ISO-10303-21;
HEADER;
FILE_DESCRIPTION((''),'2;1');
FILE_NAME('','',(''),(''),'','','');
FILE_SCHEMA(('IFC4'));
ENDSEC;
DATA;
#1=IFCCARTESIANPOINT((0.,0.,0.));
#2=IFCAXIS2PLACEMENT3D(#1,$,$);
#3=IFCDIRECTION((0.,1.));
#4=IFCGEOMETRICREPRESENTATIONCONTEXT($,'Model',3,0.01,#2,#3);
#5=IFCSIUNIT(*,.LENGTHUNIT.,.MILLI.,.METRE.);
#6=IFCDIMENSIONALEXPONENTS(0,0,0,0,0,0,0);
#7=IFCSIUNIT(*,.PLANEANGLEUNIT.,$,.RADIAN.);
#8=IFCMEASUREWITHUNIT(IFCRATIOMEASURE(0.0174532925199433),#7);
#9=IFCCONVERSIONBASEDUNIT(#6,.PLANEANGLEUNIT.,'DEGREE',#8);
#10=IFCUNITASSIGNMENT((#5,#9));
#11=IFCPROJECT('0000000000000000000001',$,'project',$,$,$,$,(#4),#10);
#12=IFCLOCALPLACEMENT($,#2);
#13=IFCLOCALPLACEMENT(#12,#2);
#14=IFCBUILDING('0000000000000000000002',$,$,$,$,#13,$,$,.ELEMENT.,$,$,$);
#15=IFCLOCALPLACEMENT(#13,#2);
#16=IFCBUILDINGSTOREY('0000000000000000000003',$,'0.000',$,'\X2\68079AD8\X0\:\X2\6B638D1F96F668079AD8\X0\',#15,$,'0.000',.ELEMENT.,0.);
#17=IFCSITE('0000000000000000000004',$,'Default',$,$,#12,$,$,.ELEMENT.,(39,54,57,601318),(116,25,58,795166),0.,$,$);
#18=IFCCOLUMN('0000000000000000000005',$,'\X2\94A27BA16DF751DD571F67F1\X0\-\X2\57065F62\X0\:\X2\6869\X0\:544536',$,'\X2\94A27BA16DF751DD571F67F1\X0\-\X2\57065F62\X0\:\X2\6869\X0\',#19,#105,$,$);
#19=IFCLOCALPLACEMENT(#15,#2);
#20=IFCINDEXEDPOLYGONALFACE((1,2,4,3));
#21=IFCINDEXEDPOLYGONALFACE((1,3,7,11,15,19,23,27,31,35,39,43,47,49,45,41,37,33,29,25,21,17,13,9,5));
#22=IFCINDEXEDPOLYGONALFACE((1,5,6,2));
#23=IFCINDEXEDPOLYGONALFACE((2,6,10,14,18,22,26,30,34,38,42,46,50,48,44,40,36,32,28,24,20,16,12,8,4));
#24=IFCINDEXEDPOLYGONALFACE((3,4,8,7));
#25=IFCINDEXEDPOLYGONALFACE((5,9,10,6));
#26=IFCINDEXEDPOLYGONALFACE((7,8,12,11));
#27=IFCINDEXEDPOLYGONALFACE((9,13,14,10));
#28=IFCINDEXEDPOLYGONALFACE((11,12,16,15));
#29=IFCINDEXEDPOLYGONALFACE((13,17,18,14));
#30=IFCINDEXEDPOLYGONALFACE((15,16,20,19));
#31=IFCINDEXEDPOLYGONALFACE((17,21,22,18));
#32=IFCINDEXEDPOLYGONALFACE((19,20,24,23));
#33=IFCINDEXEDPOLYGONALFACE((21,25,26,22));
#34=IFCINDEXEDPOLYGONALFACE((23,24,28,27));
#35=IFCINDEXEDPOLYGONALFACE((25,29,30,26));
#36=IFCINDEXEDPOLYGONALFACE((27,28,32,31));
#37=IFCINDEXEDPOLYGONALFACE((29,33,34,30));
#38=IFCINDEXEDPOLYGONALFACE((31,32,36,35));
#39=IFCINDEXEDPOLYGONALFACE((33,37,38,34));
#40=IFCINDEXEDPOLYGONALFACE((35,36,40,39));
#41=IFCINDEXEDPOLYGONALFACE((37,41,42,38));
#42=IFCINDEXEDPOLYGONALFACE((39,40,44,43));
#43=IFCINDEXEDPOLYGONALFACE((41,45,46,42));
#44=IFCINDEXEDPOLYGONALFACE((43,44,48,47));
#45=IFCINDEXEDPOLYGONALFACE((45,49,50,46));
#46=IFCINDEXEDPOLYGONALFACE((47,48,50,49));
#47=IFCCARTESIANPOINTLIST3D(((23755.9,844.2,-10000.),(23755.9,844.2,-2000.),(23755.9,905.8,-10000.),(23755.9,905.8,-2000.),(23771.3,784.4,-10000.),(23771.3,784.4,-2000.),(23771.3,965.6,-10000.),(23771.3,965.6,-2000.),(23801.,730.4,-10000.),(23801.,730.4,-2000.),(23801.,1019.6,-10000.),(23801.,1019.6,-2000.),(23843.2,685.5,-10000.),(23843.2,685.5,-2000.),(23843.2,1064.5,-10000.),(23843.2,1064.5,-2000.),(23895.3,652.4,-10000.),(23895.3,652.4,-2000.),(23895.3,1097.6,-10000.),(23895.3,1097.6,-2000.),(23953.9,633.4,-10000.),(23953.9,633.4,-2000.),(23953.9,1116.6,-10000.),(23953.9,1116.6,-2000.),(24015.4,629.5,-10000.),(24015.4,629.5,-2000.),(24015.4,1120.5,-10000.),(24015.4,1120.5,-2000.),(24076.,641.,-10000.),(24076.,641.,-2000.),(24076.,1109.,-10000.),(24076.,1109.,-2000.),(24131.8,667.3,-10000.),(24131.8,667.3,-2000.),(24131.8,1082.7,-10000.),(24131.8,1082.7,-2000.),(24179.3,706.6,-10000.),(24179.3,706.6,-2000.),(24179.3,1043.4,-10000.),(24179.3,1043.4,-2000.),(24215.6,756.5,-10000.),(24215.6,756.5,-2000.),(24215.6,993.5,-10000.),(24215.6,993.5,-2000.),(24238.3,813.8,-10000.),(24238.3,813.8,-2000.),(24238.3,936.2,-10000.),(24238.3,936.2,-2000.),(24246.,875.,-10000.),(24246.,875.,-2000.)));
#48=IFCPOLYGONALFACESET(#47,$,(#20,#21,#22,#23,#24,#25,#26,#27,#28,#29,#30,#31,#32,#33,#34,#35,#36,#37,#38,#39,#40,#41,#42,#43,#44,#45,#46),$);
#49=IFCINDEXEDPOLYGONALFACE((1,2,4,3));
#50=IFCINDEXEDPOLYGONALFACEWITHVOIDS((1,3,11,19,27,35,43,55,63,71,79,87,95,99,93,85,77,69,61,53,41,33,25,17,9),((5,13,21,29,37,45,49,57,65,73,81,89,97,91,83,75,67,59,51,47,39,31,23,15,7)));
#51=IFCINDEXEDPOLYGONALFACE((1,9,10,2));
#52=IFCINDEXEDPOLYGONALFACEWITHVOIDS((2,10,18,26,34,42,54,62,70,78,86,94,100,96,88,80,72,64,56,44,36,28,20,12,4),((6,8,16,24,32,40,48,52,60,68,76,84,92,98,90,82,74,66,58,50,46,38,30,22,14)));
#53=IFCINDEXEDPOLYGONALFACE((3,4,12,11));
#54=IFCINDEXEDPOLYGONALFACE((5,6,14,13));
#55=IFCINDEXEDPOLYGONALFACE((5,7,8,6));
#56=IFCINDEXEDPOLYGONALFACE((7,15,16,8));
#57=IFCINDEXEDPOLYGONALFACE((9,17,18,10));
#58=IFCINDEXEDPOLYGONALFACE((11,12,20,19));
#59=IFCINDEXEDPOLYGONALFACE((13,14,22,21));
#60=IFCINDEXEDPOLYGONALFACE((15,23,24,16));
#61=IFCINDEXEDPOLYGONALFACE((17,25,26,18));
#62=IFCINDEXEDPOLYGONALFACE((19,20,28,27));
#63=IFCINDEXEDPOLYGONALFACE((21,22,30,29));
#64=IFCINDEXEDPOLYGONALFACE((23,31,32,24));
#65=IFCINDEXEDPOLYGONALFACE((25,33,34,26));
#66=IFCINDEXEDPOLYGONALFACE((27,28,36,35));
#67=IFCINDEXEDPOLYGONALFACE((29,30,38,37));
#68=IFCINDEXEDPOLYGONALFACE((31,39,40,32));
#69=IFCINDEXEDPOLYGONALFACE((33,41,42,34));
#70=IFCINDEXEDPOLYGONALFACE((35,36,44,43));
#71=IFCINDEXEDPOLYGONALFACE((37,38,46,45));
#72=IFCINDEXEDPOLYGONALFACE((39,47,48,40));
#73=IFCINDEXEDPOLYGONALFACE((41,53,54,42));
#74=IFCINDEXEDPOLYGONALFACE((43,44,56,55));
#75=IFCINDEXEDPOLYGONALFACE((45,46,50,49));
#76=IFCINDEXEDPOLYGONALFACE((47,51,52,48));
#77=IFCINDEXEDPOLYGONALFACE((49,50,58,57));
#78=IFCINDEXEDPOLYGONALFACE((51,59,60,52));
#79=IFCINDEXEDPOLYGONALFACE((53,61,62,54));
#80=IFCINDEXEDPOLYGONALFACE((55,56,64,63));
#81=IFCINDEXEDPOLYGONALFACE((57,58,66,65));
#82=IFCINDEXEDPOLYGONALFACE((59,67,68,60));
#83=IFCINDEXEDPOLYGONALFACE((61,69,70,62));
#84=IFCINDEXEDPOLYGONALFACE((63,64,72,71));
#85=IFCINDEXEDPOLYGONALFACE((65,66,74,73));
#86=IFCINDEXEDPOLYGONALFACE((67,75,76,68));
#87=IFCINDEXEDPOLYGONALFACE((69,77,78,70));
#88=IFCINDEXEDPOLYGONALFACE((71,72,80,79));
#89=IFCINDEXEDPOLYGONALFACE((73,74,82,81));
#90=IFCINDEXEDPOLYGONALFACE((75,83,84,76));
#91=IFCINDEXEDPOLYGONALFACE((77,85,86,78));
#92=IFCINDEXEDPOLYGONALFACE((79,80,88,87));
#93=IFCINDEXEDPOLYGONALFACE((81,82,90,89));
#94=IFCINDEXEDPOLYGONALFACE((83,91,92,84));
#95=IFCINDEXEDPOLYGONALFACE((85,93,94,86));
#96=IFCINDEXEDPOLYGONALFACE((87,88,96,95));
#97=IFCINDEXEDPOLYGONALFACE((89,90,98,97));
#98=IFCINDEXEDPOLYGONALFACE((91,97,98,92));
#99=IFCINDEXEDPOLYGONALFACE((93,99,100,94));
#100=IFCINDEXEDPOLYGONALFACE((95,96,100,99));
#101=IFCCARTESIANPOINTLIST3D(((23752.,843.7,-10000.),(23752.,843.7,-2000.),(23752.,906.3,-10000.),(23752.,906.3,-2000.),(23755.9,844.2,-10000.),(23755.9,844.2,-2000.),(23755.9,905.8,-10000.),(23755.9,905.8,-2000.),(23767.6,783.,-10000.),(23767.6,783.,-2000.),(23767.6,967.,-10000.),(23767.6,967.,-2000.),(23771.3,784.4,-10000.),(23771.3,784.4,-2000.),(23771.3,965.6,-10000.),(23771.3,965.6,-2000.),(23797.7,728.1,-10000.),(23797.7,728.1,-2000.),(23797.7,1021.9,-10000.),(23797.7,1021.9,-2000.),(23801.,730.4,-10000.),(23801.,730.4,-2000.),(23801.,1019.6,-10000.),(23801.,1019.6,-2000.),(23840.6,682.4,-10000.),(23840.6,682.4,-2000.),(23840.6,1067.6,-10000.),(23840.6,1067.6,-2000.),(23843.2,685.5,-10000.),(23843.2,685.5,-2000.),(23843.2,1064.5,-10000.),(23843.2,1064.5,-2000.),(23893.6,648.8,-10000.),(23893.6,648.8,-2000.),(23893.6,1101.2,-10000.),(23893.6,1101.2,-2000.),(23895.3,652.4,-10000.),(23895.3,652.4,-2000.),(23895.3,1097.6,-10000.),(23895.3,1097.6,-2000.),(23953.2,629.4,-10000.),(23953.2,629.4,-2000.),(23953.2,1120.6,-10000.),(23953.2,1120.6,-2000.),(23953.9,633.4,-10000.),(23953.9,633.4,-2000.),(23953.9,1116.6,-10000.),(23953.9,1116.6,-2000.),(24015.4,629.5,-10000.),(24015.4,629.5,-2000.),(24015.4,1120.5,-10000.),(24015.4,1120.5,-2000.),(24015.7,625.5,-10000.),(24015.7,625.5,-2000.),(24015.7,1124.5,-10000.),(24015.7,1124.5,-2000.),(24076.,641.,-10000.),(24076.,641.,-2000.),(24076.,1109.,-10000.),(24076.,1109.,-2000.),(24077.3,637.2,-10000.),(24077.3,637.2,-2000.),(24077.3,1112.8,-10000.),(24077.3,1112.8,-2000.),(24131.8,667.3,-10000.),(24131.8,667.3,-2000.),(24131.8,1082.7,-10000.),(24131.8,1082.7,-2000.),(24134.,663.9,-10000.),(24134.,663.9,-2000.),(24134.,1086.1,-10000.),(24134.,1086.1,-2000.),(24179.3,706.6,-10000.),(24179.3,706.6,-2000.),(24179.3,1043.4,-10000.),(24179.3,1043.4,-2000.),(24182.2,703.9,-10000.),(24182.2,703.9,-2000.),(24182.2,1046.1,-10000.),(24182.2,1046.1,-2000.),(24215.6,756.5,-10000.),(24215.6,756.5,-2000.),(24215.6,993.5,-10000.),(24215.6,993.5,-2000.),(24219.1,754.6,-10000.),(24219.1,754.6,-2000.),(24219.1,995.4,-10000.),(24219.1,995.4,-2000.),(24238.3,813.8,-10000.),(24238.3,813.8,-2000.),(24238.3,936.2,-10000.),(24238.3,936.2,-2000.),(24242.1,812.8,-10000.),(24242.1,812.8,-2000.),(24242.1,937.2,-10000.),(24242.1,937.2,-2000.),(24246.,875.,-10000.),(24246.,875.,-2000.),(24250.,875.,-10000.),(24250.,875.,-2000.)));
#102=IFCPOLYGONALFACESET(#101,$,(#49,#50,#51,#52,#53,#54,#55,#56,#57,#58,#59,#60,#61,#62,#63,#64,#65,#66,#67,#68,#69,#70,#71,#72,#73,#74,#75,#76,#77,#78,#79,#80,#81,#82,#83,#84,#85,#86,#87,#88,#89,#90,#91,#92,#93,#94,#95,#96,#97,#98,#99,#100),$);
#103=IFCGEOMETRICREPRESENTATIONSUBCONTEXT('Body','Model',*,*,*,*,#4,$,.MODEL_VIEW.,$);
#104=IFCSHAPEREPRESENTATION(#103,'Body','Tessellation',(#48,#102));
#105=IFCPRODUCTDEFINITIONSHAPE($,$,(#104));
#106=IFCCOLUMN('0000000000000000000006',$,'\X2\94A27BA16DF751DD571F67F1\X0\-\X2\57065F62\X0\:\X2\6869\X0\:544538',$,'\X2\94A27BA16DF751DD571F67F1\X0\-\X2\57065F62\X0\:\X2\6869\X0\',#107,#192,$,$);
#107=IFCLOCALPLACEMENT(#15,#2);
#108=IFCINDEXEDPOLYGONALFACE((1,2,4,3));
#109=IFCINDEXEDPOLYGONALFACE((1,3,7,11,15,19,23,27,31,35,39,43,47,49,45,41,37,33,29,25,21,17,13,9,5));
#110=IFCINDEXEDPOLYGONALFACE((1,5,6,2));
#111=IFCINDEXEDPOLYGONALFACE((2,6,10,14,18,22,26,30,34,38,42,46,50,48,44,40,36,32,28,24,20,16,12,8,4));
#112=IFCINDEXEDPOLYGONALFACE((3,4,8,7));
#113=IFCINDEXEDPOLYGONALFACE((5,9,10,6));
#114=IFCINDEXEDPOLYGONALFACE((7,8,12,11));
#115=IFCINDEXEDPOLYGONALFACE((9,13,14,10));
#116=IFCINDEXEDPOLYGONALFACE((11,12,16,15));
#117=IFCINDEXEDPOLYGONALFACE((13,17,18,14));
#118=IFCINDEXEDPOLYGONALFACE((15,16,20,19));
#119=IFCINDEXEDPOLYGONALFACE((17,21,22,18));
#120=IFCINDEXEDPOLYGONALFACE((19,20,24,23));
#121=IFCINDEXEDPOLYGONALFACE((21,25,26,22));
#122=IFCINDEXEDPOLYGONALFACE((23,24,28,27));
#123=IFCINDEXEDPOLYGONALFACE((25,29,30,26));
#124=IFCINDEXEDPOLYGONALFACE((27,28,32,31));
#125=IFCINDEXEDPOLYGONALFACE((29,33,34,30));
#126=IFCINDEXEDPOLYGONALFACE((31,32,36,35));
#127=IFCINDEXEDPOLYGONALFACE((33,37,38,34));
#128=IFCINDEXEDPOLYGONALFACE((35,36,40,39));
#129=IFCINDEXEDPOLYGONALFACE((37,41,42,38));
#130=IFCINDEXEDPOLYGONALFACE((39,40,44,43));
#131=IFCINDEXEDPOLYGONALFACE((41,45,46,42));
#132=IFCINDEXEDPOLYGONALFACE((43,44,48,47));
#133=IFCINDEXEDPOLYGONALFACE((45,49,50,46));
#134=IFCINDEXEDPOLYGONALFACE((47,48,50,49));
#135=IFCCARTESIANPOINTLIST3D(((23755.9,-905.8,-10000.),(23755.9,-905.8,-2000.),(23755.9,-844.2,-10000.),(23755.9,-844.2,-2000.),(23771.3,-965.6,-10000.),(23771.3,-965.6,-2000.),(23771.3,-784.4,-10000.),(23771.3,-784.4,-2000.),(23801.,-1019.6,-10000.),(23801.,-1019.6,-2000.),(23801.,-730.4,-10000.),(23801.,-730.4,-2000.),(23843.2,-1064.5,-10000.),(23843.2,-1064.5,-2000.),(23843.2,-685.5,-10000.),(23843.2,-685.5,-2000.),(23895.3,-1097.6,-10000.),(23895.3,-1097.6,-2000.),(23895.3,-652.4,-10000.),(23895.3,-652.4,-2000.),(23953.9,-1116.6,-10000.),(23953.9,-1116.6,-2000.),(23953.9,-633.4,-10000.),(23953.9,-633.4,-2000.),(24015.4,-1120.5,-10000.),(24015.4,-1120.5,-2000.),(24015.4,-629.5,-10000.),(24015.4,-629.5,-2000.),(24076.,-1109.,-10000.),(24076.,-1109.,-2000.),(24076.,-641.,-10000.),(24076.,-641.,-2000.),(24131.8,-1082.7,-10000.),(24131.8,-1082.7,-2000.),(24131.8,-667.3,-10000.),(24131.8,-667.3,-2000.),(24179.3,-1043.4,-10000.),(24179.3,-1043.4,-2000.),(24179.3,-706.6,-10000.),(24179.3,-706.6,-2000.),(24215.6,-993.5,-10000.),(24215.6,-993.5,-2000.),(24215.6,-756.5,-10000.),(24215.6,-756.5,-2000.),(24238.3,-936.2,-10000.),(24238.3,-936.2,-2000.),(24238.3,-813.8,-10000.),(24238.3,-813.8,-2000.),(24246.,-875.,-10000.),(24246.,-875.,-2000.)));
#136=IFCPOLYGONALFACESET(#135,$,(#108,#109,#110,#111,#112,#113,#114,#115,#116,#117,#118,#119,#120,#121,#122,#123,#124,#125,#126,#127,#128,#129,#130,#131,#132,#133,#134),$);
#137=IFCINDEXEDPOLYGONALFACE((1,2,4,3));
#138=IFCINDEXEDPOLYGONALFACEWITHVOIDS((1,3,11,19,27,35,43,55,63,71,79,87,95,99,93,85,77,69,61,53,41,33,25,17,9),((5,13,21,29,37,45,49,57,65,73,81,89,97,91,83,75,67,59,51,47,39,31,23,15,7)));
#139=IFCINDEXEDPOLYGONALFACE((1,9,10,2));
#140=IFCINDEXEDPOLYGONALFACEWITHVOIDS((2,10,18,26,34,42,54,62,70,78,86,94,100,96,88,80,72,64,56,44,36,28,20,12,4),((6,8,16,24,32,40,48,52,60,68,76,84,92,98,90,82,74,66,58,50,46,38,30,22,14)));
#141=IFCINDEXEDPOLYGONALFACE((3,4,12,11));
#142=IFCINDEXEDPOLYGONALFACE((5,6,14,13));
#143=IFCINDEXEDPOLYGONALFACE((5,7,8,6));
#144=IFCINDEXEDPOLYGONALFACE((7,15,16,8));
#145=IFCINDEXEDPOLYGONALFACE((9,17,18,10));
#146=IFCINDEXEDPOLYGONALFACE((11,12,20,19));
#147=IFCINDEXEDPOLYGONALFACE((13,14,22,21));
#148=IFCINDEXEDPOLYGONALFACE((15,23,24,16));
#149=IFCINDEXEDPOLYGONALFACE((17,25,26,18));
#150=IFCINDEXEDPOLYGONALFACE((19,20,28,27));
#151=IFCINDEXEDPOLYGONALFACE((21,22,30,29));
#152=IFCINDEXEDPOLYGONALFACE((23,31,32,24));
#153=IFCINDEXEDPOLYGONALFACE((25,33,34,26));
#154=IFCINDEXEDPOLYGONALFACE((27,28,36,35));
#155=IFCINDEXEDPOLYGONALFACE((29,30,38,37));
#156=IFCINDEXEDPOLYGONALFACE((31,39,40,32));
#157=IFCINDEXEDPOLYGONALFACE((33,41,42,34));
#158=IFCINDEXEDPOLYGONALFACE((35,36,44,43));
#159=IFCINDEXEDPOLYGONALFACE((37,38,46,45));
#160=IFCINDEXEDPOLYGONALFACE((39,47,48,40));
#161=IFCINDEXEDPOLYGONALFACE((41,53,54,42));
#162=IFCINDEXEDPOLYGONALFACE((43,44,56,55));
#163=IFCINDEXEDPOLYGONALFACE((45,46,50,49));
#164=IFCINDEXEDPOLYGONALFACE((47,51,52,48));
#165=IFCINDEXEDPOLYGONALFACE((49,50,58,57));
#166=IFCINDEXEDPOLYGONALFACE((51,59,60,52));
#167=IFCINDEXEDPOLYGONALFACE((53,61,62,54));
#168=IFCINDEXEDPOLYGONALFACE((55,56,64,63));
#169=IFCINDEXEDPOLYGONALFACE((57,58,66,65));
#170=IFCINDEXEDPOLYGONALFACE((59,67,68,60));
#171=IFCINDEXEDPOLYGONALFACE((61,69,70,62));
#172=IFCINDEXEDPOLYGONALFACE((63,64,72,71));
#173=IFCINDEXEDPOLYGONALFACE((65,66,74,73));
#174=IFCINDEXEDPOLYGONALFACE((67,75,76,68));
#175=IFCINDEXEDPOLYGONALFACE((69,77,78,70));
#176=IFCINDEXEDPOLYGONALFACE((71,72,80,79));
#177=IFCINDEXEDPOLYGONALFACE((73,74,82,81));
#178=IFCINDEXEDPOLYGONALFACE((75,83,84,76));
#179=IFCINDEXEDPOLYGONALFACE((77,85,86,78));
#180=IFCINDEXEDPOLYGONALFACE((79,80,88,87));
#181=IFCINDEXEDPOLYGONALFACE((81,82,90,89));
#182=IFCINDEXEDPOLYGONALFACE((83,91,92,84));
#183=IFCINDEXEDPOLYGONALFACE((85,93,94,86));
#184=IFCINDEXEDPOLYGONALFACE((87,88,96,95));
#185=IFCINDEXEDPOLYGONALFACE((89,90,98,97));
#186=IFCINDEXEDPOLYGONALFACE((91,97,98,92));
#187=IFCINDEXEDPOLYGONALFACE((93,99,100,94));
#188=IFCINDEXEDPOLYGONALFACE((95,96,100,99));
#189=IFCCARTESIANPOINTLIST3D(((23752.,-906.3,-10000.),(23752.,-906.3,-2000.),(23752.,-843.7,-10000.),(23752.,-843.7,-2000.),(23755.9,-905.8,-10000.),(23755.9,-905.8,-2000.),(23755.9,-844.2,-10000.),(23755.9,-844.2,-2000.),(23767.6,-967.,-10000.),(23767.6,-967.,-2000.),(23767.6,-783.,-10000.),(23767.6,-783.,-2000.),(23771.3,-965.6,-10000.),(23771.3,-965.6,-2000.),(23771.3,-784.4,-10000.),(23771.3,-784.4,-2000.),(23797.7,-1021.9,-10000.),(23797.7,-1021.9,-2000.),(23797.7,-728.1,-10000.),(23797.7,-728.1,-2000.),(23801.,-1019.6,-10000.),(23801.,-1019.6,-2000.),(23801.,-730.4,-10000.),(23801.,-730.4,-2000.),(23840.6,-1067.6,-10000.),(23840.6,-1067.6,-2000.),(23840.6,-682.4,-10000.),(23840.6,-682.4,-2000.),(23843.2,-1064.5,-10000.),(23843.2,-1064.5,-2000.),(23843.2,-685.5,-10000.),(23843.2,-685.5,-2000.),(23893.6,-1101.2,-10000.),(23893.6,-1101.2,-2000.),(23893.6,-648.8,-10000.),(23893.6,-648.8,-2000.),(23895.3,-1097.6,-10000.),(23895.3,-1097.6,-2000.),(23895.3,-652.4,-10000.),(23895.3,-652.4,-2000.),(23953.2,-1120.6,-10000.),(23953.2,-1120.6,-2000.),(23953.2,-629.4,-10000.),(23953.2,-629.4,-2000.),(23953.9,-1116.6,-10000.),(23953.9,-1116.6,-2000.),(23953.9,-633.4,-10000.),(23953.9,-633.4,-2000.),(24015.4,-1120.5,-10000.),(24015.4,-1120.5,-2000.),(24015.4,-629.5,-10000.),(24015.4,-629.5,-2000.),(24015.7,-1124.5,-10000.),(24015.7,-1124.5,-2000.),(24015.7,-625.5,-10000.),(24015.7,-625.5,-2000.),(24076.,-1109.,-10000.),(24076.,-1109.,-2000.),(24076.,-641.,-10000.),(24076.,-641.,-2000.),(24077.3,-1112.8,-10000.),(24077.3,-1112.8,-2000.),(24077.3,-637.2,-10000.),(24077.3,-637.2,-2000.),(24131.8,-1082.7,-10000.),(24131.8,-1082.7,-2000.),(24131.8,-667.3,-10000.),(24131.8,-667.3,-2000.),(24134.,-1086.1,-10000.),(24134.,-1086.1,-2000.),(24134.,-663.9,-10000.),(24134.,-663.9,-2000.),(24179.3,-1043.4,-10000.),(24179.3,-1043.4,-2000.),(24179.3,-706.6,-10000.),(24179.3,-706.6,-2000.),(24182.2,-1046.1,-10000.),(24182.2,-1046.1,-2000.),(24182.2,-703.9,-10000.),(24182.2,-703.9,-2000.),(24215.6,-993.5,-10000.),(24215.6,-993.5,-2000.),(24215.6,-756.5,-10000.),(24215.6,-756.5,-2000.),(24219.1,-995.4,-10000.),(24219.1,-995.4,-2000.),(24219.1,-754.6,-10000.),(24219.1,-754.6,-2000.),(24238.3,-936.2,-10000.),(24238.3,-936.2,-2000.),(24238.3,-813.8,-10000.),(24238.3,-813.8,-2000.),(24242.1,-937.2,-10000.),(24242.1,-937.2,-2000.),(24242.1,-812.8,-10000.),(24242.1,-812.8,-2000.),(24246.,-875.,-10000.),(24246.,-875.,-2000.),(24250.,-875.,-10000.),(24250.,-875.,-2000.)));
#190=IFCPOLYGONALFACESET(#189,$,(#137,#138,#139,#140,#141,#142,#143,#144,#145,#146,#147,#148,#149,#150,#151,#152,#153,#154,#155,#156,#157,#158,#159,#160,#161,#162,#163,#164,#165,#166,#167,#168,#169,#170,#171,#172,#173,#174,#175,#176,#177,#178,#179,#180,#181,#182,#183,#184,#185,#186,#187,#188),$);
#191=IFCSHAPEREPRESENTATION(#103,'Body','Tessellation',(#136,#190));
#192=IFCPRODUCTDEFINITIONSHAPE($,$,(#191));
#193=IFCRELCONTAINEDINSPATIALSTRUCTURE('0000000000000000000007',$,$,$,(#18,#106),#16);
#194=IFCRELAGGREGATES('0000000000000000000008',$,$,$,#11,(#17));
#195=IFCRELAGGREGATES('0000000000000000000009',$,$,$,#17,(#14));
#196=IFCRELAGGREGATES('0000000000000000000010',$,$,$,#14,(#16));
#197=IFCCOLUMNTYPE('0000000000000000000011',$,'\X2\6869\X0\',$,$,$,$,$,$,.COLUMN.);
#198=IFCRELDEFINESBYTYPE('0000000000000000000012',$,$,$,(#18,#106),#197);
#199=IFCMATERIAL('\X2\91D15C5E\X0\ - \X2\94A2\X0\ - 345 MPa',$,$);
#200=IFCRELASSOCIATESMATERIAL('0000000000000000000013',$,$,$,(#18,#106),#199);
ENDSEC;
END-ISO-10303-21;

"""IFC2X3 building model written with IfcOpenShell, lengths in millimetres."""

from ifc_helpers import new_model, entity, si_unit, converted_unit, direction, frame, frame_2d, origin, place, context, subcontext, project, spatial, circle, hollow_circle, extrude, source, transform, mapped, material, type_object, type_shapes, element, save


model = new_model("IFC2X3")

# Units and contexts
model_context = context("Model", 3, precision=0.01, world=origin(), true_north=direction((0.0, 1.0)))
body_context = subcontext(model_context, "Body", "Model", "MODEL_VIEW")
ifc_project = project(units=[si_unit("LENGTHUNIT", "METRE", prefix="MILLI"), converted_unit("PLANEANGLEUNIT", "DEGREE", entity("IfcRatioMeasure", 0.0174532925199433), si_unit("PLANEANGLEUNIT", "RADIAN"), dimensions=[0, 0, 0, 0, 0, 0, 0])], contexts=[model_context])

# Site, building, storey
site_placement = place(None, origin())
site = spatial("IfcSite", under=ifc_project, at=site_placement, Name="Default", CompositionType="ELEMENT", RefLatitude=(39, 54, 57, 601318), RefLongitude=(116, 25, 58, 795166), RefElevation=0.0)
building_placement = place(site_placement, origin())
building = spatial("IfcBuilding", under=site, at=building_placement, CompositionType="ELEMENT")
storey_placement = place(building_placement, origin())
storey = spatial("IfcBuildingStorey", under=building, at=storey_placement, Name="0.000", ObjectType="标高:正负零标高", LongName="0.000", CompositionType="ELEMENT", Elevation=0.0)

# Columns
ifc_material_1 = material(Name="金属 - 钢 - 345 MPa")
column_type = type_object("IfcColumnType", Name="桩", PredefinedType="COLUMN")
shared_shape = source(origin(), body_context, "Body", "SweptSolid", [
    extrude(circle(Radius=246.0, at=frame_2d((0.0, 0.0), x_axis=(1.0, 0.0))), frame((0.0, 0.0, -10000.0)), (0.0, 0.0, 1.0), 8000.0),
    extrude(hollow_circle(Radius=250.0, WallThickness=4.0, at=frame_2d((0.0, 0.0), x_axis=(1.0, 0.0))), frame((0.0, 0.0, -10000.0)), (0.0, 0.0, 1.0), 8000.0),
])
type_shapes(column_type, [shared_shape])
for number, where, name in (
    (1, (24000.0, 875.0, 0.0), "钢管混凝土柱-圆形:桩:544536"),
    (2, (24000.0, -875.0, 0.0), "钢管混凝土柱-圆形:桩:544538"),
):
    element("IfcColumn", number, at=place(storey_placement, frame(where)), inside=storey, type_object=column_type, material=ifc_material_1, Name=name, ObjectType="钢管混凝土柱-圆形:桩", context=body_context, shape_type="MappedRepresentation", body=[
        mapped(shared_shape, transform((0.0, 0.0, 0.0), scale=1.0)),
    ])

save(model, "model.ifc")
